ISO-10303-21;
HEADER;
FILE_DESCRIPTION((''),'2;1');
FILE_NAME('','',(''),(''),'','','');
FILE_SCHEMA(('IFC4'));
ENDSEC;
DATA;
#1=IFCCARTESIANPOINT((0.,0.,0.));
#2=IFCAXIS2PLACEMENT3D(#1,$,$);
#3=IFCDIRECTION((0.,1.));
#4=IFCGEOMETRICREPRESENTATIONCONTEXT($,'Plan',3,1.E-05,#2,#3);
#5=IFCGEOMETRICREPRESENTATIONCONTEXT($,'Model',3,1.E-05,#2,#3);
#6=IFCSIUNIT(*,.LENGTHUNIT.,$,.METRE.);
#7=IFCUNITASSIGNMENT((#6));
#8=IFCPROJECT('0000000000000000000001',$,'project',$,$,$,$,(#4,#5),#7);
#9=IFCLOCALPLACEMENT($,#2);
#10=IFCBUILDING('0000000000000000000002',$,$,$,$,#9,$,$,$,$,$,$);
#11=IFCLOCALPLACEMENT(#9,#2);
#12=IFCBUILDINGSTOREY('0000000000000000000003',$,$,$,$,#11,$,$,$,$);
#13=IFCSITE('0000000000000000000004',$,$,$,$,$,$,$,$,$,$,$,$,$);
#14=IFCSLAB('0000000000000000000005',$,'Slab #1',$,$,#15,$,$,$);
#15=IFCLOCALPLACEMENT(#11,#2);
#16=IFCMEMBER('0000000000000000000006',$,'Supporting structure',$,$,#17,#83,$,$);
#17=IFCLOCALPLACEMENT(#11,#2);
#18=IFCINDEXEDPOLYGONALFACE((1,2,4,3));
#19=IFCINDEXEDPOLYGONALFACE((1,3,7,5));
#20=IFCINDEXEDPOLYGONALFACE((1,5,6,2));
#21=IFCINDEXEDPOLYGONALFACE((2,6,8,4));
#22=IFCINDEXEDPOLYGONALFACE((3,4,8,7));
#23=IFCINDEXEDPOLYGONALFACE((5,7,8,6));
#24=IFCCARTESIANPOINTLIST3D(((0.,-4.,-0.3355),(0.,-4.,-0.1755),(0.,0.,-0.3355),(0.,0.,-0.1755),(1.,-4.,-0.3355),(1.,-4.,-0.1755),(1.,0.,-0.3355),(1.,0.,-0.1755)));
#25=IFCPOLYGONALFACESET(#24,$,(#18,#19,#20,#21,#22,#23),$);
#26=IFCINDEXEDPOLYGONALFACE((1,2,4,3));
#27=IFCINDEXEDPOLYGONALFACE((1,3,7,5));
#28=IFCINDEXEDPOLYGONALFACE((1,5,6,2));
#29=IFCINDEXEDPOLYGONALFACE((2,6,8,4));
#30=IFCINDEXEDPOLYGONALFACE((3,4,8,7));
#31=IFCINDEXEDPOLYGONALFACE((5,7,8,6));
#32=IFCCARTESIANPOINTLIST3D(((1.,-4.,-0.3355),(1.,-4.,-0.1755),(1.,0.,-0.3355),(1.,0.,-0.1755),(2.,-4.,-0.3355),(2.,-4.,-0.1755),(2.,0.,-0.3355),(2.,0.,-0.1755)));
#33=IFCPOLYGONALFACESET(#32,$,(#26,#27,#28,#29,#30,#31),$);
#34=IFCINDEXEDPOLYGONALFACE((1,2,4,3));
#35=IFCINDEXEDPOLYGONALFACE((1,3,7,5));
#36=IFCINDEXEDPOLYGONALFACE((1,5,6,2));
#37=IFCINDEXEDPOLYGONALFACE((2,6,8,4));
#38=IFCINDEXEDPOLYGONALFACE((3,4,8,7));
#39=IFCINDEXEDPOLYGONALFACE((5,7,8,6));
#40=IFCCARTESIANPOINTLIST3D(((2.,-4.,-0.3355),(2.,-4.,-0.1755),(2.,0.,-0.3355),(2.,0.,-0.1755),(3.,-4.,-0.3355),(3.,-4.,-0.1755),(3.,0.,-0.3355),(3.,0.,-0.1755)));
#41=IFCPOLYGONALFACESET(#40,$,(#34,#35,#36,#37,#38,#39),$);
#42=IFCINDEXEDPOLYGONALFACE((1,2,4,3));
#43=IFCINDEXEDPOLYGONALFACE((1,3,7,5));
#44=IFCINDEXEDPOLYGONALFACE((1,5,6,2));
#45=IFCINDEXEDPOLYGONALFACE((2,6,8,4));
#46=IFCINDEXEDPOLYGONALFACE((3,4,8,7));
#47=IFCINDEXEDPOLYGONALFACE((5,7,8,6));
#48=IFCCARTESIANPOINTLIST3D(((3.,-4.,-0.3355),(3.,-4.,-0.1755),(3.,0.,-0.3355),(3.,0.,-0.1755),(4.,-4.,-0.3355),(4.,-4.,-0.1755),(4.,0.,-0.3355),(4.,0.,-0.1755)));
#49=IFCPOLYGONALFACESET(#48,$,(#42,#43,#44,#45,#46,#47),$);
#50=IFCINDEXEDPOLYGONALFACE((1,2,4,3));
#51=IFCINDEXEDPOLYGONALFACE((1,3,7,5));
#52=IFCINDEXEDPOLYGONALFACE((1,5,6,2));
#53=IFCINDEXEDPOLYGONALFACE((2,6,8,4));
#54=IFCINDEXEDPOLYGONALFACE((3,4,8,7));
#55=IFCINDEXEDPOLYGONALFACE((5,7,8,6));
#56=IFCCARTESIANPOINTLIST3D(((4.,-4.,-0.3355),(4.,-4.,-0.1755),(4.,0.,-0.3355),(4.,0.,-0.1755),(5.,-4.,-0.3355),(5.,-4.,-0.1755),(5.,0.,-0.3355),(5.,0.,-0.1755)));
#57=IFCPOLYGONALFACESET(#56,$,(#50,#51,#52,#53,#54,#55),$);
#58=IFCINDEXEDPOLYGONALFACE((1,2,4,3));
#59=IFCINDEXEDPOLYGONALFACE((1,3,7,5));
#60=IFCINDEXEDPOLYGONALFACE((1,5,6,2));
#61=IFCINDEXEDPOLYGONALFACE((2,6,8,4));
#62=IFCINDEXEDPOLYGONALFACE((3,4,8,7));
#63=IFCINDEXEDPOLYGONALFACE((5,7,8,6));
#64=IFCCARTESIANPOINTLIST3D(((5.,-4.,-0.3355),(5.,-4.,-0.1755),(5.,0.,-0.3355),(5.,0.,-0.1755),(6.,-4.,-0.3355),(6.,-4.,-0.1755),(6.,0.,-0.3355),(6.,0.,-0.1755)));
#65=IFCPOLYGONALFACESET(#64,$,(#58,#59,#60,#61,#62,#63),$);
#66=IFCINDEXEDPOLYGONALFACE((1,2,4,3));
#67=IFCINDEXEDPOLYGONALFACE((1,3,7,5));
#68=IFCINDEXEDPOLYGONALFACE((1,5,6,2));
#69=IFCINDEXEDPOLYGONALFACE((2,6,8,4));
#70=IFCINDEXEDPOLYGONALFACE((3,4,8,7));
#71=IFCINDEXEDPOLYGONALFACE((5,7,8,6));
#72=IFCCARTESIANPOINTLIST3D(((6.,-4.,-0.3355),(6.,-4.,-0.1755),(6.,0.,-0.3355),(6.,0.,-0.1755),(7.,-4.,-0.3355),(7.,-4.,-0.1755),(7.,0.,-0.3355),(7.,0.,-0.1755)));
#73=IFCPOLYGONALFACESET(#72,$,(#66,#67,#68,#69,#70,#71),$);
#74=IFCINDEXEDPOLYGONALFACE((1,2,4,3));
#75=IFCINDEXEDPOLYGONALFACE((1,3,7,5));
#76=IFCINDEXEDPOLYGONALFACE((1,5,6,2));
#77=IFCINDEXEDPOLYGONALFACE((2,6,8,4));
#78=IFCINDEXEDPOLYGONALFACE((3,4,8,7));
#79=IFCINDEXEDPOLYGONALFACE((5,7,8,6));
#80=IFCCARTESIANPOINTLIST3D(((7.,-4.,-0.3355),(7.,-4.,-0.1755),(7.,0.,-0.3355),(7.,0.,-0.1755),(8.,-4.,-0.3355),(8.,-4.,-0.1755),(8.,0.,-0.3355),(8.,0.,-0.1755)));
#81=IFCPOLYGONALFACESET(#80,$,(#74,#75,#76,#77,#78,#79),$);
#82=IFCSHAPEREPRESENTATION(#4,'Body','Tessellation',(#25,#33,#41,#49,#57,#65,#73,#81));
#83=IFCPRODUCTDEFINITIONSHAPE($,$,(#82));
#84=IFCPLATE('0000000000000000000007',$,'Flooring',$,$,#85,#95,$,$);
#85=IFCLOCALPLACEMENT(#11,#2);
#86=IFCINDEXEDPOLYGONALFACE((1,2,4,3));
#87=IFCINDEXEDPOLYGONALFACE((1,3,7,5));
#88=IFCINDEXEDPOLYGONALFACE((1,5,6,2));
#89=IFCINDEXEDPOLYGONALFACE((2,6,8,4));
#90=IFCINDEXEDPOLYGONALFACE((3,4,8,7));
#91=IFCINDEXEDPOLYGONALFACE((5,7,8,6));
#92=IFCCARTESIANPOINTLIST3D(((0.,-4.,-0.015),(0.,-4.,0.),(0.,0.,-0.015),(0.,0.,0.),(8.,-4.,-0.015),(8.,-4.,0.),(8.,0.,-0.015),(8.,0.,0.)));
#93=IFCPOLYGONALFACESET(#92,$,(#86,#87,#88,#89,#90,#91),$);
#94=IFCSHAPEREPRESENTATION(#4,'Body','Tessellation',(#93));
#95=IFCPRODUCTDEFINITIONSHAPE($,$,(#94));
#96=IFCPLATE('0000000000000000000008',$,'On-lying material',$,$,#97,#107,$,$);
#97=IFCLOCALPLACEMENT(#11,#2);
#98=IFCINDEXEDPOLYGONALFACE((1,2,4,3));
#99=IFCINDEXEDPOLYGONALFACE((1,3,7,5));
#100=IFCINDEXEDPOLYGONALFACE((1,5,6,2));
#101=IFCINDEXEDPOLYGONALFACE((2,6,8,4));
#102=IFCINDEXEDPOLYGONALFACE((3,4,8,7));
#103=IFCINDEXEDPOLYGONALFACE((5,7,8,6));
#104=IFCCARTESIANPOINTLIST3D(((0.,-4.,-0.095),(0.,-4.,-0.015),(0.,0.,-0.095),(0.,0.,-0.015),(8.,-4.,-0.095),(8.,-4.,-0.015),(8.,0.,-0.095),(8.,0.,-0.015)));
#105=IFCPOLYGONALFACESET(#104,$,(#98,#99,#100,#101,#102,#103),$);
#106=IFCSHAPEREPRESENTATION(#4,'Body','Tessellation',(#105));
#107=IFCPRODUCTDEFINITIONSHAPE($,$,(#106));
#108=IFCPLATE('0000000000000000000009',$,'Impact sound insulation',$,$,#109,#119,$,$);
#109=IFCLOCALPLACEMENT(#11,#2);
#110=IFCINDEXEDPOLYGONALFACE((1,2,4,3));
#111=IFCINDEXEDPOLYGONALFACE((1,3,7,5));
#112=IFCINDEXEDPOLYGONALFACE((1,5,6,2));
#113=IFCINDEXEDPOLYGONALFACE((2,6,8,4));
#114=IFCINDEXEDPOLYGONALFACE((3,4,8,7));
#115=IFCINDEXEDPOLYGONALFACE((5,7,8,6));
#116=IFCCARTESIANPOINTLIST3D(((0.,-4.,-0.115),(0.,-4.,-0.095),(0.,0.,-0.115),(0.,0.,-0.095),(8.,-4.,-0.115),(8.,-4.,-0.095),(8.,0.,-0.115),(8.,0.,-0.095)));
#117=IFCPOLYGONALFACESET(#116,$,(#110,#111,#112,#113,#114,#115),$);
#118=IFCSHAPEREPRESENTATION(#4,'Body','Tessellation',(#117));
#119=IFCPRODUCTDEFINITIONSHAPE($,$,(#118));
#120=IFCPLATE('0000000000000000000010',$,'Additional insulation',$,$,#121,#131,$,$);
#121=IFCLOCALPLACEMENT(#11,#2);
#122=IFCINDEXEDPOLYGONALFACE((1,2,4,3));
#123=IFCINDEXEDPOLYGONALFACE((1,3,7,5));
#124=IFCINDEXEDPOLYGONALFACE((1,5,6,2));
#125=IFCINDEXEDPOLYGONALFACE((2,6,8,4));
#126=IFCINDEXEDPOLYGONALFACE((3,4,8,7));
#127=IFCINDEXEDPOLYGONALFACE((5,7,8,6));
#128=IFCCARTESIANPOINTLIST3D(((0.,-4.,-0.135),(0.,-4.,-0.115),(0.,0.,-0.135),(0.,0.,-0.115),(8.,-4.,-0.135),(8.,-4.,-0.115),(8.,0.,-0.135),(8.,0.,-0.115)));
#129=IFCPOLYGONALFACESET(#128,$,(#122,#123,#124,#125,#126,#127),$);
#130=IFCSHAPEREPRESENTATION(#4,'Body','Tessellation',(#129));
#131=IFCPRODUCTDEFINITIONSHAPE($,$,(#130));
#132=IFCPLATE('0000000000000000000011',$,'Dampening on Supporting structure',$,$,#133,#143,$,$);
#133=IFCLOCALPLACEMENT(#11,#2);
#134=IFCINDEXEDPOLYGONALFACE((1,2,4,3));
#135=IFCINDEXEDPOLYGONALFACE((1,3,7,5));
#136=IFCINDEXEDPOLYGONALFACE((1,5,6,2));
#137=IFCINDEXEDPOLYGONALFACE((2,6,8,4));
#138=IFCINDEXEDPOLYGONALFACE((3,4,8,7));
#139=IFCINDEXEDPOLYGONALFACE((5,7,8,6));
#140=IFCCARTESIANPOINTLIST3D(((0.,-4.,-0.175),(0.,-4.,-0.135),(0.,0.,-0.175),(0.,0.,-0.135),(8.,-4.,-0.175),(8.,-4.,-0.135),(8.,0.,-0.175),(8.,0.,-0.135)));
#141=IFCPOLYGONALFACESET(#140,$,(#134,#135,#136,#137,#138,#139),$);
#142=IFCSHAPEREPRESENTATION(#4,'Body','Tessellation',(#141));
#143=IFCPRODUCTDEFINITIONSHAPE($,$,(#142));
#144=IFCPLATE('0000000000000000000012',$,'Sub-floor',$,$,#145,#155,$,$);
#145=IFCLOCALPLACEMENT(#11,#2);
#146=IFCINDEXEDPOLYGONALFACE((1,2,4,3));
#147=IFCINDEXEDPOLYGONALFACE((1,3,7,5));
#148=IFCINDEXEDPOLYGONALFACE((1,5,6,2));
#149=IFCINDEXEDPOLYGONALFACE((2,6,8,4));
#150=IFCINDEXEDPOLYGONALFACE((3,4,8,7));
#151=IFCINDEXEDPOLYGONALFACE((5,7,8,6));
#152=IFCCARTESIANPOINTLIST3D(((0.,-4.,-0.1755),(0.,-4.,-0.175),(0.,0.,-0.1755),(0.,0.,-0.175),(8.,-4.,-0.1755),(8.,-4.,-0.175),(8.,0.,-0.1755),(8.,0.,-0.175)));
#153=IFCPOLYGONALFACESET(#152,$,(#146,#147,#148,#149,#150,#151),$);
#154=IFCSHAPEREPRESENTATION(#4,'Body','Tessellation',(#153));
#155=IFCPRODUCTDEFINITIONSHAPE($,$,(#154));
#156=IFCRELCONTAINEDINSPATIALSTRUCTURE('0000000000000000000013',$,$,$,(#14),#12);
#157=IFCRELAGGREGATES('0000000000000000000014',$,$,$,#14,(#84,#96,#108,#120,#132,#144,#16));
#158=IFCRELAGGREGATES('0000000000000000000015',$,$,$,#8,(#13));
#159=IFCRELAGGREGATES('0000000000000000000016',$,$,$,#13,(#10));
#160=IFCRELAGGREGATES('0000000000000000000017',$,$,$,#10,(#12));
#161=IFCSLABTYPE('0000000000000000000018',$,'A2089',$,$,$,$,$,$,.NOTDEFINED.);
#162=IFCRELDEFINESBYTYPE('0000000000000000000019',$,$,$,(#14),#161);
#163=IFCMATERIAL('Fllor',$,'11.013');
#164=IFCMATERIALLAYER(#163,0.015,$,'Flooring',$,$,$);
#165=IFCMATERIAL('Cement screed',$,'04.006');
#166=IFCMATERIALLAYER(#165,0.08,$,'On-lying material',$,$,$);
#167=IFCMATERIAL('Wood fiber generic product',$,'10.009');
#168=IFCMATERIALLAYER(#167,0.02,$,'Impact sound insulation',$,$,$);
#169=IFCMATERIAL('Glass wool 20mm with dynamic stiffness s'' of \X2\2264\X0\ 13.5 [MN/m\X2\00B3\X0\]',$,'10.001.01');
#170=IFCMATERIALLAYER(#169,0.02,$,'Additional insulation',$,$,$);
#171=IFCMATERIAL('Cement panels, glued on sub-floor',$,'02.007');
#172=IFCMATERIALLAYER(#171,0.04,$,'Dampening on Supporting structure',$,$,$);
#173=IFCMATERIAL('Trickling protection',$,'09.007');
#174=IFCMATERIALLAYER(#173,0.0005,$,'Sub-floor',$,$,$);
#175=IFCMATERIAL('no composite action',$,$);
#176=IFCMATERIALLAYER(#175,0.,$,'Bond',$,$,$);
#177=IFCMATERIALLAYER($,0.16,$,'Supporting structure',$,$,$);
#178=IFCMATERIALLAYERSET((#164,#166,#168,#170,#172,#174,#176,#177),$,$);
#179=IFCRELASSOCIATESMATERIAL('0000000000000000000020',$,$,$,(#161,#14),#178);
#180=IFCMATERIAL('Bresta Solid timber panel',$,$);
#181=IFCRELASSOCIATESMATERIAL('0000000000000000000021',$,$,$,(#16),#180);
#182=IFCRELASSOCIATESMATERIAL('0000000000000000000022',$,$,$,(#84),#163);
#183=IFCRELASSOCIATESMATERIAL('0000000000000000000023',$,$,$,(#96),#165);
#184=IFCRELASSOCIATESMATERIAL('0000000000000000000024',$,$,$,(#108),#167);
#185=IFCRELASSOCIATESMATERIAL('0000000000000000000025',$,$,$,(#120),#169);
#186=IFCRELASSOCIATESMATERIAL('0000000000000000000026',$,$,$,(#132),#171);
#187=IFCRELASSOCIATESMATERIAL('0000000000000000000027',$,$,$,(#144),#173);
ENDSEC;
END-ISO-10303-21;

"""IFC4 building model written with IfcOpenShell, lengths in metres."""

from ifc_helpers import new_model, si_unit, direction, frame, frame_2d, origin, origin_with_axes, place, context, project, spatial, rectangle, extrude, material, layer, layer_set, type_object, element, aggregate, save


model = new_model("IFC4")

# Units and contexts
plan_context = context("Plan", 3, precision=1e-05, world=origin(), true_north=direction((0.0, 1.0)))
model_context = context("Model", 3, precision=1e-05, world=origin(), true_north=direction((0.0, 1.0)))
ifc_project = project(units=[si_unit("LENGTHUNIT", "METRE")], contexts=[plan_context, model_context])

# Site, building, storey
site = spatial("IfcSite", under=ifc_project)
building_placement = place(None, origin())
building = spatial("IfcBuilding", under=site, at=building_placement)
storey_placement = place(building_placement, origin())
storey = spatial("IfcBuildingStorey", under=building, at=storey_placement)

# Slab, member, plates
ifc_material_1 = material(Name="Fllor", Category="11.013")
ifc_layer_1 = layer(ifc_material_1, 0.015, Name="Flooring")
ifc_material_2 = material(Name="Cement screed", Category="04.006")
ifc_layer_2 = layer(ifc_material_2, 0.08, Name="On-lying material")
ifc_material_3 = material(Name="Wood fiber generic product", Category="10.009")
ifc_layer_3 = layer(ifc_material_3, 0.02, Name="Impact sound insulation")
ifc_material_4 = material(Name="Glass wool 20mm with dynamic stiffness s' of ≤ 13.5 [MN/m³]", Category="10.001.01")
ifc_layer_4 = layer(ifc_material_4, 0.02, Name="Additional insulation")
ifc_material_5 = material(Name="Cement panels, glued on sub-floor", Category="02.007")
ifc_layer_5 = layer(ifc_material_5, 0.04, Name="Dampening on Supporting structure")
ifc_material_6 = material(Name="Trickling protection", Category="09.007")
ifc_layer_6 = layer(ifc_material_6, 0.0005, Name="Sub-floor")
ifc_material_7 = material(Name="no composite action")
ifc_layer_7 = layer(ifc_material_7, 0.0, Name="Bond")
ifc_layer_8 = layer(None, 0.16, Name="Supporting structure")
ifc_layer_set = layer_set([ifc_layer_1, ifc_layer_2, ifc_layer_3, ifc_layer_4, ifc_layer_5, ifc_layer_6, ifc_layer_7, ifc_layer_8])
slab_type = type_object("IfcSlabType", Name="A2089", PredefinedType="NOTDEFINED", material=ifc_layer_set)
slab_placement = place(None, frame((0.0, 0.0, 0.0), z_axis=(0.0, 0.0, -1.0), x_axis=(1.0, 0.0, 0.0)))
slab = element("IfcSlab", 1, at=slab_placement, inside=storey, type_object=slab_type, material=ifc_layer_set, Name="Slab #1")
ifc_material_8 = material(Name="Bresta Solid timber panel")
member_placement = place(slab_placement, origin())
member = element("IfcMember", 2, at=member_placement, material=ifc_material_8, Name="Supporting structure", context=plan_context, shape_type="SweptSolid", body=[
    extrude(rectangle(XDim=1.0, YDim=0.16, at=frame_2d((0.5, 0.08), x_axis=(1.0, 0.0))), frame((0.0, 4.0, 0.1755), z_axis=(0.0, -1.0, 0.0), x_axis=(1.0, 0.0, 0.0)), (0.0, 0.0, 1.0), 4.0),
    extrude(rectangle(XDim=1.0, YDim=0.16, at=frame_2d((0.5, 0.08), x_axis=(1.0, 0.0))), frame((1.0, 4.0, 0.1755), z_axis=(0.0, -1.0, 0.0), x_axis=(1.0, 0.0, 0.0)), (0.0, 0.0, 1.0), 4.0),
    extrude(rectangle(XDim=1.0, YDim=0.16, at=frame_2d((0.5, 0.08), x_axis=(1.0, 0.0))), frame((2.0, 4.0, 0.1755), z_axis=(0.0, -1.0, 0.0), x_axis=(1.0, 0.0, 0.0)), (0.0, 0.0, 1.0), 4.0),
    extrude(rectangle(XDim=1.0, YDim=0.16, at=frame_2d((0.5, 0.08), x_axis=(1.0, 0.0))), frame((3.0, 4.0, 0.1755), z_axis=(0.0, -1.0, 0.0), x_axis=(1.0, 0.0, 0.0)), (0.0, 0.0, 1.0), 4.0),
    extrude(rectangle(XDim=1.0, YDim=0.16, at=frame_2d((0.5, 0.08), x_axis=(1.0, 0.0))), frame((4.0, 4.0, 0.1755), z_axis=(0.0, -1.0, 0.0), x_axis=(1.0, 0.0, 0.0)), (0.0, 0.0, 1.0), 4.0),
    extrude(rectangle(XDim=1.0, YDim=0.16, at=frame_2d((0.5, 0.08), x_axis=(1.0, 0.0))), frame((5.0, 4.0, 0.1755), z_axis=(0.0, -1.0, 0.0), x_axis=(1.0, 0.0, 0.0)), (0.0, 0.0, 1.0), 4.0),
    extrude(rectangle(XDim=1.0, YDim=0.16, at=frame_2d((0.5, 0.08), x_axis=(1.0, 0.0))), frame((6.0, 4.0, 0.1755), z_axis=(0.0, -1.0, 0.0), x_axis=(1.0, 0.0, 0.0)), (0.0, 0.0, 1.0), 4.0),
    extrude(rectangle(XDim=1.0, YDim=0.16, at=frame_2d((0.5, 0.08), x_axis=(1.0, 0.0))), frame((7.0, 4.0, 0.1755), z_axis=(0.0, -1.0, 0.0), x_axis=(1.0, 0.0, 0.0)), (0.0, 0.0, 1.0), 4.0),
])
plate_1_placement = place(slab_placement, origin())
plate_1 = element("IfcPlate", 3, at=plate_1_placement, material=ifc_material_1, Name="Flooring", context=plan_context, shape_type="SweptSolid", body=[
    extrude(rectangle(XDim=8.0, YDim=4.0, at=frame_2d((4.0, 2.0), x_axis=(1.0, 0.0))), origin_with_axes(), (0.0, 0.0, 1.0), 0.015),
])
plate_2_placement = place(slab_placement, origin())
plate_2 = element("IfcPlate", 4, at=plate_2_placement, material=ifc_material_2, Name="On-lying material", context=plan_context, shape_type="SweptSolid", body=[
    extrude(rectangle(XDim=8.0, YDim=4.0, at=frame_2d((4.0, 2.0), x_axis=(1.0, 0.0))), frame((0.0, 0.0, 0.015), z_axis=(0.0, 0.0, 1.0), x_axis=(1.0, 0.0, 0.0)), (0.0, 0.0, 1.0), 0.08),
])
plate_3_placement = place(slab_placement, origin())
plate_3 = element("IfcPlate", 5, at=plate_3_placement, material=ifc_material_3, Name="Impact sound insulation", context=plan_context, shape_type="SweptSolid", body=[
    extrude(rectangle(XDim=8.0, YDim=4.0, at=frame_2d((4.0, 2.0), x_axis=(1.0, 0.0))), frame((0.0, 0.0, 0.095), z_axis=(0.0, 0.0, 1.0), x_axis=(1.0, 0.0, 0.0)), (0.0, 0.0, 1.0), 0.02),
])
plate_4_placement = place(slab_placement, origin())
plate_4 = element("IfcPlate", 6, at=plate_4_placement, material=ifc_material_4, Name="Additional insulation", context=plan_context, shape_type="SweptSolid", body=[
    extrude(rectangle(XDim=8.0, YDim=4.0, at=frame_2d((4.0, 2.0), x_axis=(1.0, 0.0))), frame((0.0, 0.0, 0.115), z_axis=(0.0, 0.0, 1.0), x_axis=(1.0, 0.0, 0.0)), (0.0, 0.0, 1.0), 0.02),
])
plate_5_placement = place(slab_placement, origin())
plate_5 = element("IfcPlate", 7, at=plate_5_placement, material=ifc_material_5, Name="Dampening on Supporting structure", context=plan_context, shape_type="SweptSolid", body=[
    extrude(rectangle(XDim=8.0, YDim=4.0, at=frame_2d((4.0, 2.0), x_axis=(1.0, 0.0))), frame((0.0, 0.0, 0.135), z_axis=(0.0, 0.0, 1.0), x_axis=(1.0, 0.0, 0.0)), (0.0, 0.0, 1.0), 0.04),
])
plate_6_placement = place(slab_placement, origin())
plate_6 = element("IfcPlate", 8, at=plate_6_placement, material=ifc_material_6, Name="Sub-floor", context=plan_context, shape_type="SweptSolid", body=[
    extrude(rectangle(XDim=8.0, YDim=4.0, at=frame_2d((4.0, 2.0), x_axis=(1.0, 0.0))), frame((0.0, 0.0, 0.175), z_axis=(0.0, 0.0, 1.0), x_axis=(1.0, 0.0, 0.0)), (0.0, 0.0, 1.0), 0.0005),
])
aggregate(slab, [plate_1, plate_2, plate_3, plate_4, plate_5, plate_6, member])

save(model, "model.ifc")
